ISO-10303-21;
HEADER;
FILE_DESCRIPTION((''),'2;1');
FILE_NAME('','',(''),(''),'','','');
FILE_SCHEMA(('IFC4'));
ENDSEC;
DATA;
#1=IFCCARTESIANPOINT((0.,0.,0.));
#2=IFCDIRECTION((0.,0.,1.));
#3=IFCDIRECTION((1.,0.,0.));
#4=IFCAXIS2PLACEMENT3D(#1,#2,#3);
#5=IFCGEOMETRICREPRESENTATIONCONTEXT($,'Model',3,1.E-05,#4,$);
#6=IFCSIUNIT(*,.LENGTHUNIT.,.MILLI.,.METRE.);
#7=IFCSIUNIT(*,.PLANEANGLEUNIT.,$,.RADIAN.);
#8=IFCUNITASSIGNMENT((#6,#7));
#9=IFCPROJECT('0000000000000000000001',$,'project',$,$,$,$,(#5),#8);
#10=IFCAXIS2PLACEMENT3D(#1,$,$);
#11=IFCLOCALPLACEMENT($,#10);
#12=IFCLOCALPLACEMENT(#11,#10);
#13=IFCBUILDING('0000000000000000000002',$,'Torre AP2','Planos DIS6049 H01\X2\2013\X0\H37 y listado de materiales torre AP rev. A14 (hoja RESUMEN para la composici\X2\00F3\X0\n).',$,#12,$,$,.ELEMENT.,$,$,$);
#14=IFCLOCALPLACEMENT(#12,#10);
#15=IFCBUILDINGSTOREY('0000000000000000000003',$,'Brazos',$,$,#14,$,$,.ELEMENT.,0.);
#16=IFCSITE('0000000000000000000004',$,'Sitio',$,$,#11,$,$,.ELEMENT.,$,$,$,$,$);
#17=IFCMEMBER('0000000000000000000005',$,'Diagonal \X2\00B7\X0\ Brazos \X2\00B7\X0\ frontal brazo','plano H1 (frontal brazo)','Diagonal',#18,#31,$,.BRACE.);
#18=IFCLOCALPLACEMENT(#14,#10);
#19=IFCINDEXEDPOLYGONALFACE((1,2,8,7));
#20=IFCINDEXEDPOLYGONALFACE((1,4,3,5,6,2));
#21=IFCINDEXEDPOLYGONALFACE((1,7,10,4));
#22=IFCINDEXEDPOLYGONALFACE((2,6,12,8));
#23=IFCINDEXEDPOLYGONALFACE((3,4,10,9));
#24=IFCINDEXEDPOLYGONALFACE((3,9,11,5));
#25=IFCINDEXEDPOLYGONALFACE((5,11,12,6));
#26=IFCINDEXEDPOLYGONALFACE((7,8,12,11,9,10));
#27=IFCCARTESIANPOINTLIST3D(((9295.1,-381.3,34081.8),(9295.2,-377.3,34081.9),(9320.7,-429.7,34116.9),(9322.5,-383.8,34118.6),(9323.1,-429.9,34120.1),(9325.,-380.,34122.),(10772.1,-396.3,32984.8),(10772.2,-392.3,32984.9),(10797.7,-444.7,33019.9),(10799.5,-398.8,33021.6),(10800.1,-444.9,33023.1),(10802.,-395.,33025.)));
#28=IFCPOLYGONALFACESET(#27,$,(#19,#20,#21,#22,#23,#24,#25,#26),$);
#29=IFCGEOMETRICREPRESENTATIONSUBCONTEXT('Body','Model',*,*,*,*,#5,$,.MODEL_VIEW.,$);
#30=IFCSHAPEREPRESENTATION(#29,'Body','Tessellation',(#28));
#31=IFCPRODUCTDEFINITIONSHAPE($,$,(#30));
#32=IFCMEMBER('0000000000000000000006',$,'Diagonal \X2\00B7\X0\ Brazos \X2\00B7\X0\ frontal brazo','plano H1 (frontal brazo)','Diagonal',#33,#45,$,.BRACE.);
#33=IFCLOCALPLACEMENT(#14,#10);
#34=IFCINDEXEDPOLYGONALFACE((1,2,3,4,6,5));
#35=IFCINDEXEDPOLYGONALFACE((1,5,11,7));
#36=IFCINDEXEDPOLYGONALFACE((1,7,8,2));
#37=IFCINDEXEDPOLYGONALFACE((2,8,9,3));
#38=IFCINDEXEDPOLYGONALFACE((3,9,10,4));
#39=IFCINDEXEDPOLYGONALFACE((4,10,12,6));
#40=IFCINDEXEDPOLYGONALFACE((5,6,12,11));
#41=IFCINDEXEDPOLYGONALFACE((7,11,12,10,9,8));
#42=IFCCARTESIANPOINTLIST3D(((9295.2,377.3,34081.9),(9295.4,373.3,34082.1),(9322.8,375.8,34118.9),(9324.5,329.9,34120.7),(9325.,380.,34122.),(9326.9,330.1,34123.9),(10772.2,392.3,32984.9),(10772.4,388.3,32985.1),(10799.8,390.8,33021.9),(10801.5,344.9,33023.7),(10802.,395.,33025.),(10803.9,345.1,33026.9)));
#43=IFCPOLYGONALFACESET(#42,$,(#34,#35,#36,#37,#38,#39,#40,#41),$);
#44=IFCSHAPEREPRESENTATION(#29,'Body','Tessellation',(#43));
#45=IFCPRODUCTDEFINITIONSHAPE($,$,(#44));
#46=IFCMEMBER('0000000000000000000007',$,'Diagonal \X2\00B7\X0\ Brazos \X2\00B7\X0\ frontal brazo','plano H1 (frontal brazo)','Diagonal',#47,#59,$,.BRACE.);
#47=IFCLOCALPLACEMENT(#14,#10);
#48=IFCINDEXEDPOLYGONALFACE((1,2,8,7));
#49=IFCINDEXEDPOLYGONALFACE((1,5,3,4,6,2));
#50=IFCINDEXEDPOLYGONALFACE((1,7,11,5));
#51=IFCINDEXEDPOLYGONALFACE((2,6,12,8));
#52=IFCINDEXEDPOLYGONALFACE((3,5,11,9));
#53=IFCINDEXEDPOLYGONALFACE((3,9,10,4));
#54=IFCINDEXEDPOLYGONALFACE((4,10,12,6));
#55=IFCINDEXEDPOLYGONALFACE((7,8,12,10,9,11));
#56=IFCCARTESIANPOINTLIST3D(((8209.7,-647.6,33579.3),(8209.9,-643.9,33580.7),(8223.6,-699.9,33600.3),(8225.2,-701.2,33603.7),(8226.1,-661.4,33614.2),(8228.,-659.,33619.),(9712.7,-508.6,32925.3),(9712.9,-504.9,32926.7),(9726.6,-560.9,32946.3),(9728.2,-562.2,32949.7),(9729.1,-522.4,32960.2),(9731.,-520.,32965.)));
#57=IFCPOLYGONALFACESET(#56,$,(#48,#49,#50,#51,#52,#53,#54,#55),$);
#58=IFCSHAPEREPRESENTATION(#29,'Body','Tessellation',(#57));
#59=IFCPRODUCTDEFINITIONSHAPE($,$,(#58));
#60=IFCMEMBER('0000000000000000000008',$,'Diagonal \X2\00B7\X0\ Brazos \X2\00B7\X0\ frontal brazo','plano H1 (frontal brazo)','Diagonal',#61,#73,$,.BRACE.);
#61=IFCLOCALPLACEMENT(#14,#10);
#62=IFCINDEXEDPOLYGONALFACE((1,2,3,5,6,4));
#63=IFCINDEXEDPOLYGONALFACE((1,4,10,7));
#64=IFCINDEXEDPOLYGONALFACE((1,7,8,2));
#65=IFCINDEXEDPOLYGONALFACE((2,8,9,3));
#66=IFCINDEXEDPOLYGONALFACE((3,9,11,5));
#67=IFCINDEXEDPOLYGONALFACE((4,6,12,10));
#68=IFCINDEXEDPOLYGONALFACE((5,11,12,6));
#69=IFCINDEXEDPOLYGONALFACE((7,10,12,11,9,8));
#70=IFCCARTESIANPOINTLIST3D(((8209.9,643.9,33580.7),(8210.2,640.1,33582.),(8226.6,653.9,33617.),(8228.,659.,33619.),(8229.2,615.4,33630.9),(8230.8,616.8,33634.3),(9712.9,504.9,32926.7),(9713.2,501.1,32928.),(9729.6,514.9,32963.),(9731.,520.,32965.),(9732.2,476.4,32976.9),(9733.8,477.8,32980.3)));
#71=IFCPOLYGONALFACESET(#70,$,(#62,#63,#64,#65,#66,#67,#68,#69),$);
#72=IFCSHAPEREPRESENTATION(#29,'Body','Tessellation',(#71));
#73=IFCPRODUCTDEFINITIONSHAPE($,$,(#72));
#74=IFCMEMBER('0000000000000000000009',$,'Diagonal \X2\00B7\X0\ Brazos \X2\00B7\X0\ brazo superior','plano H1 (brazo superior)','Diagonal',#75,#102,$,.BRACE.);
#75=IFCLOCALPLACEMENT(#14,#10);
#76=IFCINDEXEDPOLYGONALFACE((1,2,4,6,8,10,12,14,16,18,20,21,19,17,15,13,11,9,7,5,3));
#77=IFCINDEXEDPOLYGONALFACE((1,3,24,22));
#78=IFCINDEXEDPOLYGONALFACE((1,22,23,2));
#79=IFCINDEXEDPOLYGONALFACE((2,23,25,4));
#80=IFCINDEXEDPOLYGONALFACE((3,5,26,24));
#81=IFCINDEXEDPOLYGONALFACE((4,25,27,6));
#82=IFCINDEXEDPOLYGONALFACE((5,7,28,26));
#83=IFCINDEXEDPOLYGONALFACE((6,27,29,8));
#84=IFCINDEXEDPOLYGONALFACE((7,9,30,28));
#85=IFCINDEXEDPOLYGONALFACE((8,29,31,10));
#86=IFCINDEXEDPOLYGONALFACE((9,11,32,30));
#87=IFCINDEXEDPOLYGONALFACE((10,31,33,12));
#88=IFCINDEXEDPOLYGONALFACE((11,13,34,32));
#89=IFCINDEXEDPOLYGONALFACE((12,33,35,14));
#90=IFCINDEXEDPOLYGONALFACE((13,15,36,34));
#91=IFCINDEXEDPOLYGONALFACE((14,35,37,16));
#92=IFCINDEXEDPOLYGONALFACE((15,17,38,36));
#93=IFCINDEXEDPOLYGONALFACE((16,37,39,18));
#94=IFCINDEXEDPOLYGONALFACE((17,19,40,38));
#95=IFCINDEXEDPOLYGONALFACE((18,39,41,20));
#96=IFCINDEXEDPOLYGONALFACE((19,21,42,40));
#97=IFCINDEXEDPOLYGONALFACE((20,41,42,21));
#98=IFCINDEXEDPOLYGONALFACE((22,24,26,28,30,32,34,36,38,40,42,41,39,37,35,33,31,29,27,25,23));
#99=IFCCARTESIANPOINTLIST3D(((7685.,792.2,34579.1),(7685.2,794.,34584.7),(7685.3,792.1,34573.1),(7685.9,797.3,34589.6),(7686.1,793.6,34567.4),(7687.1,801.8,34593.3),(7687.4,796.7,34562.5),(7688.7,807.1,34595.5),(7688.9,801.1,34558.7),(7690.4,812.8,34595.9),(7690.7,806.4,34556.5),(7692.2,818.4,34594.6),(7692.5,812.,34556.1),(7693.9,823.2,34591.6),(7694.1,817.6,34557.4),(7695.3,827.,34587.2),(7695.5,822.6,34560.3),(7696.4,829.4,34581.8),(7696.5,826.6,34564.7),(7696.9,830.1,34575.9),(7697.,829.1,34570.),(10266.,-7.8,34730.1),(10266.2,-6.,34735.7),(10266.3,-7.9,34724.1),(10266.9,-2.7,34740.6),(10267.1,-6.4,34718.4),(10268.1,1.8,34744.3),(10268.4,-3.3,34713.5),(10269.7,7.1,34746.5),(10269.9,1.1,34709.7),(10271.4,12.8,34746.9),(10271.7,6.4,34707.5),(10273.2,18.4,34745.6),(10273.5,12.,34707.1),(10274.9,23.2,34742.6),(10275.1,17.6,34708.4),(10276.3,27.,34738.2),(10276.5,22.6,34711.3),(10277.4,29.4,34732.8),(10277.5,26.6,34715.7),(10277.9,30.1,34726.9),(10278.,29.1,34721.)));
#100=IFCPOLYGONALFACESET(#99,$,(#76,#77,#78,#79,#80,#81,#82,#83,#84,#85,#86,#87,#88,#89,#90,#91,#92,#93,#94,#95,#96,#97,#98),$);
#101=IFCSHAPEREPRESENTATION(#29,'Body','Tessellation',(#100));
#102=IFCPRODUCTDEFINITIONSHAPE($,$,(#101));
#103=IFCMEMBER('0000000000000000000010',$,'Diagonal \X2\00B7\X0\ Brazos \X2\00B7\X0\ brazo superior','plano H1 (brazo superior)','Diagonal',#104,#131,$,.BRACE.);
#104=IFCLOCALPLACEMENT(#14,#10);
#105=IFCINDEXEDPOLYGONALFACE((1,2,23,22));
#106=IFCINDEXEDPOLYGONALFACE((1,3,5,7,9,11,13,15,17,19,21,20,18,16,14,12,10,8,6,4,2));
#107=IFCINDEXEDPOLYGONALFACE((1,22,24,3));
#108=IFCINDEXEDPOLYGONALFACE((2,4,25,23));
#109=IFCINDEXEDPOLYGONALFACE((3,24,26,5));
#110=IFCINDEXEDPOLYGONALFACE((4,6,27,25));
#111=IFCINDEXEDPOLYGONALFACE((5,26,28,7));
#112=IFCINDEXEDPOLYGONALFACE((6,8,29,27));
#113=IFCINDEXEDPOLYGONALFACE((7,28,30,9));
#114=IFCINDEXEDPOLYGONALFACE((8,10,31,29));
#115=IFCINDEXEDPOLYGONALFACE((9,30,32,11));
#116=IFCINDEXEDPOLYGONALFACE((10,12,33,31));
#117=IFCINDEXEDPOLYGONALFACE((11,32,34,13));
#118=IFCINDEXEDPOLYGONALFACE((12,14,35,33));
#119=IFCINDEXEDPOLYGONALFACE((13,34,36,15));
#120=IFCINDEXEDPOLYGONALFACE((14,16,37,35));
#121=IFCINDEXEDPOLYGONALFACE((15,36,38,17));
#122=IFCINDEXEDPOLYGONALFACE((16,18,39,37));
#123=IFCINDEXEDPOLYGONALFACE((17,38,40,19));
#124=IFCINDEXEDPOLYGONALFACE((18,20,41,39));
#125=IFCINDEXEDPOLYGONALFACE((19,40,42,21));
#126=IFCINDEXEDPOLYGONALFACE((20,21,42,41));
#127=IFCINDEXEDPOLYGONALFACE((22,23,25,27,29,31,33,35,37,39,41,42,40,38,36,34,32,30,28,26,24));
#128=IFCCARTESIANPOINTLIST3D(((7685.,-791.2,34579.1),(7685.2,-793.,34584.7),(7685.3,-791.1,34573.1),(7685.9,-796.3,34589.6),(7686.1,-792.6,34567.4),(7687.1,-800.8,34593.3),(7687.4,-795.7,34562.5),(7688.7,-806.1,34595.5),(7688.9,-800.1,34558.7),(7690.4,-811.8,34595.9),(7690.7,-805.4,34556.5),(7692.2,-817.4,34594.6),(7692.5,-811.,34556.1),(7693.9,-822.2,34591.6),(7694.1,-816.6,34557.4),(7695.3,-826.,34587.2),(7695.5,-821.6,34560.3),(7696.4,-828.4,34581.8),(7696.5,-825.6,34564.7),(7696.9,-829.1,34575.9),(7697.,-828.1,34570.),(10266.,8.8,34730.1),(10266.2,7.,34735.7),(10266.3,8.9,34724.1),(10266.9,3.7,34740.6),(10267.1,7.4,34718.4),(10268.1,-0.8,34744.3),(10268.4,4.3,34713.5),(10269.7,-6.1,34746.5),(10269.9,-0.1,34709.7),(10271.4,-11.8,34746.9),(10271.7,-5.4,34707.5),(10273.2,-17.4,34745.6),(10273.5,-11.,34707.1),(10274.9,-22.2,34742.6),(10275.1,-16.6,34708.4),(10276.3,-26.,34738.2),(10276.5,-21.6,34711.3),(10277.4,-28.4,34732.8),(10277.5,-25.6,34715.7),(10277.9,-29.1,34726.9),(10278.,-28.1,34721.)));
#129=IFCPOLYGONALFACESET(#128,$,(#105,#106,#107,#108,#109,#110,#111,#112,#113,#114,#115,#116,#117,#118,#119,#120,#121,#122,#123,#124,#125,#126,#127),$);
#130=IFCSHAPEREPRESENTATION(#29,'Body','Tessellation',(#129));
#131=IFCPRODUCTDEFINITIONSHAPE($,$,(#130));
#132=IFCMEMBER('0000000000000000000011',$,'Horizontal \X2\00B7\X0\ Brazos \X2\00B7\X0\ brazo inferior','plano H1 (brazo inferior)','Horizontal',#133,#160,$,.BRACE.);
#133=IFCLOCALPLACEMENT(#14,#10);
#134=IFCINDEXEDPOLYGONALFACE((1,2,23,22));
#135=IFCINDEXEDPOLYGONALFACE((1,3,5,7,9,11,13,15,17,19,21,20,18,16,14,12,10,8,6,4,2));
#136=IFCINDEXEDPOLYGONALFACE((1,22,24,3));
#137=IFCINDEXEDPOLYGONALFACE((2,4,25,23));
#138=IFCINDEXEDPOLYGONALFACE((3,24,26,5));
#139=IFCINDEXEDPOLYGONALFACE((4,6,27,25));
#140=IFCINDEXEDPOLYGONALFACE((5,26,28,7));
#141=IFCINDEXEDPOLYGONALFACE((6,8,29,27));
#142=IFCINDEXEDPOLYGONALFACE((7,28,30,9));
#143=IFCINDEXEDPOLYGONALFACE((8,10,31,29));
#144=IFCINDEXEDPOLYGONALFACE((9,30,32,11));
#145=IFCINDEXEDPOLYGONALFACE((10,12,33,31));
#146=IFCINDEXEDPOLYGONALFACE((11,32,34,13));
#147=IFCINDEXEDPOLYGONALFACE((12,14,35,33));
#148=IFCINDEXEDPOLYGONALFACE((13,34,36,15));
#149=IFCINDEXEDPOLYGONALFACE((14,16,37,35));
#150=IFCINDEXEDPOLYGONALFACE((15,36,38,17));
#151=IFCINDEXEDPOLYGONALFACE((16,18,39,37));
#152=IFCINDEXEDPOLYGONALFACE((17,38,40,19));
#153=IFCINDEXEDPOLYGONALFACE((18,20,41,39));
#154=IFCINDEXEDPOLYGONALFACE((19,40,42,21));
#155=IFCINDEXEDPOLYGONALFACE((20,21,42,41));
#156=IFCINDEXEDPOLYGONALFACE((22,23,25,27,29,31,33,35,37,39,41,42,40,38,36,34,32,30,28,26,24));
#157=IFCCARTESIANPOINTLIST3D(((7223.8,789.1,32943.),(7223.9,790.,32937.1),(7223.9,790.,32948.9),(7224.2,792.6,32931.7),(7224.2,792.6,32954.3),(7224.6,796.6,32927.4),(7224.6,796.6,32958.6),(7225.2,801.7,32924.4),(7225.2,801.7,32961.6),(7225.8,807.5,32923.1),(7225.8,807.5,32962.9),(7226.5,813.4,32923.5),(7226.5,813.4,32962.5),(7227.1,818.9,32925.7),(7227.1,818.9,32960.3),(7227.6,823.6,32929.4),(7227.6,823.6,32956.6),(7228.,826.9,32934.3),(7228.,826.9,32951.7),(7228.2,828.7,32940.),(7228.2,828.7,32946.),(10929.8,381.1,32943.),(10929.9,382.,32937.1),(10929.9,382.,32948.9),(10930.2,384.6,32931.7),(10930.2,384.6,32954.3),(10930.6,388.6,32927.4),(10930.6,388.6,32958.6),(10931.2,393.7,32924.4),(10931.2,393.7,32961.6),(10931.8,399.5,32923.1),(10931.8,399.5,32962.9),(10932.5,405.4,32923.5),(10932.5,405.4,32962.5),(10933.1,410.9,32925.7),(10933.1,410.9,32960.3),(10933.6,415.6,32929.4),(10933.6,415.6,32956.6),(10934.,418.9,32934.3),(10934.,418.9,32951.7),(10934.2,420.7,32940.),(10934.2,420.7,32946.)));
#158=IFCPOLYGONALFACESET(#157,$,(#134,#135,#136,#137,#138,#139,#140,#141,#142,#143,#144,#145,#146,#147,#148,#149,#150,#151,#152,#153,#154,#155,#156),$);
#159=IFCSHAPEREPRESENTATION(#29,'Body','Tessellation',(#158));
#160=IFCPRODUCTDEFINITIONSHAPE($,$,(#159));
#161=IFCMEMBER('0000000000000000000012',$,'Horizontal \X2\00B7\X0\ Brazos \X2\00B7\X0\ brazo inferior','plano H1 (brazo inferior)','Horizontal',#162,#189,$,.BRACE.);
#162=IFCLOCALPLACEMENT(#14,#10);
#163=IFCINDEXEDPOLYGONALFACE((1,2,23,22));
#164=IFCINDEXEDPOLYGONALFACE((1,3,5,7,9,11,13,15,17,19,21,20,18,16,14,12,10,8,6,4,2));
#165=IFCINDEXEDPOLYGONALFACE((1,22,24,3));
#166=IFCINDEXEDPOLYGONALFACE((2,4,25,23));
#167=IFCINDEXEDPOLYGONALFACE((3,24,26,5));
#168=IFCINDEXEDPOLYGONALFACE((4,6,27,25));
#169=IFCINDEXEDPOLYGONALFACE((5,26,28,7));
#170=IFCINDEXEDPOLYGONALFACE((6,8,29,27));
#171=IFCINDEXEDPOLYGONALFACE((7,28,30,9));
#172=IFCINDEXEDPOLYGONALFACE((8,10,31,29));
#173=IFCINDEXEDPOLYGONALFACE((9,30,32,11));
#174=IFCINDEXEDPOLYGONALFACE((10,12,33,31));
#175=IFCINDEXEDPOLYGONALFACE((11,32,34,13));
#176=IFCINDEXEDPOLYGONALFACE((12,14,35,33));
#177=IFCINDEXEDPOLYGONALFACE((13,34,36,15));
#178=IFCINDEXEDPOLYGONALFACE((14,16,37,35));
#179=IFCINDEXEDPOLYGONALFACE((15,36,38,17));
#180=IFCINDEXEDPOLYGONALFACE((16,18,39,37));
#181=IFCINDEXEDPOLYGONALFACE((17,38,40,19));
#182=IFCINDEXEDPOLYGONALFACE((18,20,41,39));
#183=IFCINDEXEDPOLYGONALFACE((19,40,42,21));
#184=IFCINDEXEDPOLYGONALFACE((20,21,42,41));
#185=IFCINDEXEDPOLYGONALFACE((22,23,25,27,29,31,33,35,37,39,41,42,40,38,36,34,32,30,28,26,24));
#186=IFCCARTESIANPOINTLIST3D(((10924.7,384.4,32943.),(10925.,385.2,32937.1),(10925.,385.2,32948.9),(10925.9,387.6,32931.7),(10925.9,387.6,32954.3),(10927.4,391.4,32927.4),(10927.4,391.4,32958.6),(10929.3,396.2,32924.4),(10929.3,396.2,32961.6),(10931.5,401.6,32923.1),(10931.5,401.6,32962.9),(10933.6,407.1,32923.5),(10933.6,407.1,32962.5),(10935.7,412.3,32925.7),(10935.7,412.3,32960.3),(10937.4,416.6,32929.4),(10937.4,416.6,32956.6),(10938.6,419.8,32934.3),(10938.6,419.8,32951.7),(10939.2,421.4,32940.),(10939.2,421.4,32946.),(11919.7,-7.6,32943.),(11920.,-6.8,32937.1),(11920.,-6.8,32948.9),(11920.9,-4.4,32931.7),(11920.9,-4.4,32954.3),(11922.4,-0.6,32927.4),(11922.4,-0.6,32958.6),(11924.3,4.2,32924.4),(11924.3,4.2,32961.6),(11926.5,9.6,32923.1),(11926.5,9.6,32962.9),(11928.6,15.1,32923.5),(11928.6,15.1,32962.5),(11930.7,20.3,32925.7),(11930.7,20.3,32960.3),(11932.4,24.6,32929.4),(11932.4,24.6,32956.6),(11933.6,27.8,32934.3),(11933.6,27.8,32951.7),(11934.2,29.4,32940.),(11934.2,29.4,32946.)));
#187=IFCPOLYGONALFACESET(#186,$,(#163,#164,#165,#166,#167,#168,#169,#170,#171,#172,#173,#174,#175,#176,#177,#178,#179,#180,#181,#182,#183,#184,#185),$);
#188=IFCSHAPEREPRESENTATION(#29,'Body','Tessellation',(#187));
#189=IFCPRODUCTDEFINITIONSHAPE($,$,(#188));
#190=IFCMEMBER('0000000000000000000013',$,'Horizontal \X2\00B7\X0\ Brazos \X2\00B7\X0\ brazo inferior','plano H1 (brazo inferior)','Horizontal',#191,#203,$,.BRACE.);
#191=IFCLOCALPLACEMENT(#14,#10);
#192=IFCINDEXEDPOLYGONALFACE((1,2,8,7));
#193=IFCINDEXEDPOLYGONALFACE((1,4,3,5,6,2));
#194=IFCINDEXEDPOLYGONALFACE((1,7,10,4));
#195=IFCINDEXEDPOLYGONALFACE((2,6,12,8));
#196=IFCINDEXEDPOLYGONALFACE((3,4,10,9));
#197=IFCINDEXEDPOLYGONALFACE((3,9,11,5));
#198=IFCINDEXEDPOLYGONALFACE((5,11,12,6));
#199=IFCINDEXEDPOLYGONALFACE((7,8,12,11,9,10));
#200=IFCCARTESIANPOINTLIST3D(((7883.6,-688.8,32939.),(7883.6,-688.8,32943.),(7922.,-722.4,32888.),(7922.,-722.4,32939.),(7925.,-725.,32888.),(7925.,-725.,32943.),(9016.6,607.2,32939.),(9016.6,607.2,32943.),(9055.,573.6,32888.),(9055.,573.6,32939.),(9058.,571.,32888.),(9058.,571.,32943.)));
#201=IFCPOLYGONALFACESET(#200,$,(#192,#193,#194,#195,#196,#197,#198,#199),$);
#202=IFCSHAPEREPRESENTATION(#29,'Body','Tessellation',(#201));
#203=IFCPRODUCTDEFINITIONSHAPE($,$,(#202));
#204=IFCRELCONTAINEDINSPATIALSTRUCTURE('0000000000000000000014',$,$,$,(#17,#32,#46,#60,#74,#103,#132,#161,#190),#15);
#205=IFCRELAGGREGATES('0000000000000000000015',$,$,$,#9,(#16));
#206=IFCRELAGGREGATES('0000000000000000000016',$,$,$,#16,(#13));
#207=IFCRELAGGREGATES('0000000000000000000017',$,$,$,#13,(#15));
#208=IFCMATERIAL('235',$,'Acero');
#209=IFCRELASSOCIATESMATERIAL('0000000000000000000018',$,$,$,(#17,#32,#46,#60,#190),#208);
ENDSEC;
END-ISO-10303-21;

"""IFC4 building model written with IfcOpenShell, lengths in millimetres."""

from ifc_helpers import new_model, si_unit, frame, frame_2d, origin, origin_with_axes, place, context, subcontext, project, spatial, circle, l_section, extrude, material, element, save


model = new_model("IFC4")

# Units and contexts
model_context = context("Model", 3, precision=1e-05, world=origin_with_axes())
body_context = subcontext(model_context, "Body", "Model", "MODEL_VIEW")
ifc_project = project(units=[si_unit("LENGTHUNIT", "METRE", prefix="MILLI"), si_unit("PLANEANGLEUNIT", "RADIAN")], contexts=[model_context])

# Site, building, storey
site_placement = place(None, origin())
site = spatial("IfcSite", under=ifc_project, at=site_placement, Name="Sitio", CompositionType="ELEMENT")
building_placement = place(site_placement, origin())
building = spatial("IfcBuilding", under=site, at=building_placement, Name="Torre AP2", Description="Planos DIS6049 H01–H37 y listado de materiales torre AP rev. A14 (hoja RESUMEN para la composición).", CompositionType="ELEMENT")
storey_placement = place(building_placement, origin())
storey = spatial("IfcBuildingStorey", under=building, at=storey_placement, Name="Brazos", CompositionType="ELEMENT", Elevation=0.0)

# Members
ifc_material_1 = material(Name="235", Category="Acero")
for number, where, z_axis, x_axis, name in (
    (1, (10802.0, -395.0, 33025.0), (-0.802769, 0.008153, 0.596234), (-0.595049, 0.053521, -0.801905), "Diagonal · Brazos · frontal brazo"),
    (2, (10802.0, 395.0, 33025.0), (-0.802769, -0.008153, 0.596234), (-0.595049, -0.053521, -0.801905), "Diagonal · Brazos · frontal brazo"),
):
    element("IfcMember", number, at=place(storey_placement, frame(where, z_axis=z_axis, x_axis=x_axis)), inside=storey, material=ifc_material_1, Name=name, Description="plano H1 (frontal brazo)", ObjectType="Diagonal", PredefinedType="BRACE", context=body_context, shape_type="SweptSolid", body=[
        extrude(l_section(Depth=50.0, Width=50.0, Thickness=4.0, at=frame_2d((25.0, 25.0))), None, (0.0, 0.0, 1.0), 1839.9),
    ])
for number, where, z_axis, x_axis, name in (
    (3, (9731.0, -520.0, 32965.0), (-0.913674, -0.084498, 0.397567), (-0.401755, 0.335963, -0.851893), "Diagonal · Brazos · frontal brazo"),
    (4, (9731.0, 520.0, 32965.0), (-0.913674, 0.084498, 0.397567), (-0.401755, -0.335963, -0.851893), "Diagonal · Brazos · frontal brazo"),
):
    element("IfcMember", number, at=place(storey_placement, frame(where, z_axis=z_axis, x_axis=x_axis)), inside=storey, material=ifc_material_1, Name=name, Description="plano H1 (frontal brazo)", ObjectType="Diagonal", PredefinedType="BRACE", context=body_context, shape_type="SweptSolid", body=[
        extrude(l_section(Depth=45.0, Width=45.0, Thickness=4.0, at=frame_2d((22.5, 22.5))), None, (0.0, 0.0, 1.0), 1645.0),
    ])
for number, where, z_axis, x_axis, name in (
    (5, (7691.0, 811.0, 34576.0), (0.953681, -0.2956, 0.055795), (-0.300728, -0.941427, 0.152572), "Diagonal · Brazos · brazo superior"),
    (6, (10272.0, -10.0, 34727.0), (-0.953681, -0.2956, -0.055795), (-0.300729, 0.941418, 0.152624), "Diagonal · Brazos · brazo superior"),
):
    element("IfcMember", number, at=place(storey_placement, frame(where, z_axis=z_axis, x_axis=x_axis)), inside=storey, Name=name, Description="plano H1 (brazo superior)", ObjectType="Diagonal", PredefinedType="BRACE", context=body_context, shape_type="SweptSolid", body=[
        extrude(circle(Radius=20.0), None, (0.0, 0.0, 1.0), 2706.4),
    ])
member_1_placement = place(storey_placement, frame((7226.0, 809.0, 32943.0), z_axis=(0.993994, -0.109431, 0.0), x_axis=(-0.109431, -0.993994, 0.0)))
element("IfcMember", 7, at=member_1_placement, inside=storey, Name="Horizontal · Brazos · brazo inferior", Description="plano H1 (brazo inferior)", ObjectType="Horizontal", PredefinedType="BRACE", context=body_context, shape_type="SweptSolid", body=[
    extrude(circle(Radius=20.0), None, (0.0, 0.0, 1.0), 3728.4),
])
member_2_placement = place(storey_placement, frame((10932.0, 403.0, 32943.0), z_axis=(0.930399, -0.366549, 0.0), x_axis=(-0.366549, -0.930399, 0.0)))
element("IfcMember", 8, at=member_2_placement, inside=storey, Name="Horizontal · Brazos · brazo inferior", Description="plano H1 (brazo inferior)", ObjectType="Horizontal", PredefinedType="BRACE", context=body_context, shape_type="SweptSolid", body=[
    extrude(circle(Radius=20.0), None, (0.0, 0.0, 1.0), 1069.4),
])
member_3_placement = place(storey_placement, frame((9058.0, 571.0, 32943.0), z_axis=(-0.658176, -0.752865, 0.0), x_axis=(-0.752865, 0.658176, 0.0)))
element("IfcMember", 9, at=member_3_placement, inside=storey, material=ifc_material_1, Name="Horizontal · Brazos · brazo inferior", Description="plano H1 (brazo inferior)", ObjectType="Horizontal", PredefinedType="BRACE", context=body_context, shape_type="SweptSolid", body=[
    extrude(l_section(Depth=55.0, Width=55.0, Thickness=4.0, at=frame_2d((27.5, 27.5))), None, (0.0, 0.0, 1.0), 1721.4),
])

save(model, "model.ifc")
